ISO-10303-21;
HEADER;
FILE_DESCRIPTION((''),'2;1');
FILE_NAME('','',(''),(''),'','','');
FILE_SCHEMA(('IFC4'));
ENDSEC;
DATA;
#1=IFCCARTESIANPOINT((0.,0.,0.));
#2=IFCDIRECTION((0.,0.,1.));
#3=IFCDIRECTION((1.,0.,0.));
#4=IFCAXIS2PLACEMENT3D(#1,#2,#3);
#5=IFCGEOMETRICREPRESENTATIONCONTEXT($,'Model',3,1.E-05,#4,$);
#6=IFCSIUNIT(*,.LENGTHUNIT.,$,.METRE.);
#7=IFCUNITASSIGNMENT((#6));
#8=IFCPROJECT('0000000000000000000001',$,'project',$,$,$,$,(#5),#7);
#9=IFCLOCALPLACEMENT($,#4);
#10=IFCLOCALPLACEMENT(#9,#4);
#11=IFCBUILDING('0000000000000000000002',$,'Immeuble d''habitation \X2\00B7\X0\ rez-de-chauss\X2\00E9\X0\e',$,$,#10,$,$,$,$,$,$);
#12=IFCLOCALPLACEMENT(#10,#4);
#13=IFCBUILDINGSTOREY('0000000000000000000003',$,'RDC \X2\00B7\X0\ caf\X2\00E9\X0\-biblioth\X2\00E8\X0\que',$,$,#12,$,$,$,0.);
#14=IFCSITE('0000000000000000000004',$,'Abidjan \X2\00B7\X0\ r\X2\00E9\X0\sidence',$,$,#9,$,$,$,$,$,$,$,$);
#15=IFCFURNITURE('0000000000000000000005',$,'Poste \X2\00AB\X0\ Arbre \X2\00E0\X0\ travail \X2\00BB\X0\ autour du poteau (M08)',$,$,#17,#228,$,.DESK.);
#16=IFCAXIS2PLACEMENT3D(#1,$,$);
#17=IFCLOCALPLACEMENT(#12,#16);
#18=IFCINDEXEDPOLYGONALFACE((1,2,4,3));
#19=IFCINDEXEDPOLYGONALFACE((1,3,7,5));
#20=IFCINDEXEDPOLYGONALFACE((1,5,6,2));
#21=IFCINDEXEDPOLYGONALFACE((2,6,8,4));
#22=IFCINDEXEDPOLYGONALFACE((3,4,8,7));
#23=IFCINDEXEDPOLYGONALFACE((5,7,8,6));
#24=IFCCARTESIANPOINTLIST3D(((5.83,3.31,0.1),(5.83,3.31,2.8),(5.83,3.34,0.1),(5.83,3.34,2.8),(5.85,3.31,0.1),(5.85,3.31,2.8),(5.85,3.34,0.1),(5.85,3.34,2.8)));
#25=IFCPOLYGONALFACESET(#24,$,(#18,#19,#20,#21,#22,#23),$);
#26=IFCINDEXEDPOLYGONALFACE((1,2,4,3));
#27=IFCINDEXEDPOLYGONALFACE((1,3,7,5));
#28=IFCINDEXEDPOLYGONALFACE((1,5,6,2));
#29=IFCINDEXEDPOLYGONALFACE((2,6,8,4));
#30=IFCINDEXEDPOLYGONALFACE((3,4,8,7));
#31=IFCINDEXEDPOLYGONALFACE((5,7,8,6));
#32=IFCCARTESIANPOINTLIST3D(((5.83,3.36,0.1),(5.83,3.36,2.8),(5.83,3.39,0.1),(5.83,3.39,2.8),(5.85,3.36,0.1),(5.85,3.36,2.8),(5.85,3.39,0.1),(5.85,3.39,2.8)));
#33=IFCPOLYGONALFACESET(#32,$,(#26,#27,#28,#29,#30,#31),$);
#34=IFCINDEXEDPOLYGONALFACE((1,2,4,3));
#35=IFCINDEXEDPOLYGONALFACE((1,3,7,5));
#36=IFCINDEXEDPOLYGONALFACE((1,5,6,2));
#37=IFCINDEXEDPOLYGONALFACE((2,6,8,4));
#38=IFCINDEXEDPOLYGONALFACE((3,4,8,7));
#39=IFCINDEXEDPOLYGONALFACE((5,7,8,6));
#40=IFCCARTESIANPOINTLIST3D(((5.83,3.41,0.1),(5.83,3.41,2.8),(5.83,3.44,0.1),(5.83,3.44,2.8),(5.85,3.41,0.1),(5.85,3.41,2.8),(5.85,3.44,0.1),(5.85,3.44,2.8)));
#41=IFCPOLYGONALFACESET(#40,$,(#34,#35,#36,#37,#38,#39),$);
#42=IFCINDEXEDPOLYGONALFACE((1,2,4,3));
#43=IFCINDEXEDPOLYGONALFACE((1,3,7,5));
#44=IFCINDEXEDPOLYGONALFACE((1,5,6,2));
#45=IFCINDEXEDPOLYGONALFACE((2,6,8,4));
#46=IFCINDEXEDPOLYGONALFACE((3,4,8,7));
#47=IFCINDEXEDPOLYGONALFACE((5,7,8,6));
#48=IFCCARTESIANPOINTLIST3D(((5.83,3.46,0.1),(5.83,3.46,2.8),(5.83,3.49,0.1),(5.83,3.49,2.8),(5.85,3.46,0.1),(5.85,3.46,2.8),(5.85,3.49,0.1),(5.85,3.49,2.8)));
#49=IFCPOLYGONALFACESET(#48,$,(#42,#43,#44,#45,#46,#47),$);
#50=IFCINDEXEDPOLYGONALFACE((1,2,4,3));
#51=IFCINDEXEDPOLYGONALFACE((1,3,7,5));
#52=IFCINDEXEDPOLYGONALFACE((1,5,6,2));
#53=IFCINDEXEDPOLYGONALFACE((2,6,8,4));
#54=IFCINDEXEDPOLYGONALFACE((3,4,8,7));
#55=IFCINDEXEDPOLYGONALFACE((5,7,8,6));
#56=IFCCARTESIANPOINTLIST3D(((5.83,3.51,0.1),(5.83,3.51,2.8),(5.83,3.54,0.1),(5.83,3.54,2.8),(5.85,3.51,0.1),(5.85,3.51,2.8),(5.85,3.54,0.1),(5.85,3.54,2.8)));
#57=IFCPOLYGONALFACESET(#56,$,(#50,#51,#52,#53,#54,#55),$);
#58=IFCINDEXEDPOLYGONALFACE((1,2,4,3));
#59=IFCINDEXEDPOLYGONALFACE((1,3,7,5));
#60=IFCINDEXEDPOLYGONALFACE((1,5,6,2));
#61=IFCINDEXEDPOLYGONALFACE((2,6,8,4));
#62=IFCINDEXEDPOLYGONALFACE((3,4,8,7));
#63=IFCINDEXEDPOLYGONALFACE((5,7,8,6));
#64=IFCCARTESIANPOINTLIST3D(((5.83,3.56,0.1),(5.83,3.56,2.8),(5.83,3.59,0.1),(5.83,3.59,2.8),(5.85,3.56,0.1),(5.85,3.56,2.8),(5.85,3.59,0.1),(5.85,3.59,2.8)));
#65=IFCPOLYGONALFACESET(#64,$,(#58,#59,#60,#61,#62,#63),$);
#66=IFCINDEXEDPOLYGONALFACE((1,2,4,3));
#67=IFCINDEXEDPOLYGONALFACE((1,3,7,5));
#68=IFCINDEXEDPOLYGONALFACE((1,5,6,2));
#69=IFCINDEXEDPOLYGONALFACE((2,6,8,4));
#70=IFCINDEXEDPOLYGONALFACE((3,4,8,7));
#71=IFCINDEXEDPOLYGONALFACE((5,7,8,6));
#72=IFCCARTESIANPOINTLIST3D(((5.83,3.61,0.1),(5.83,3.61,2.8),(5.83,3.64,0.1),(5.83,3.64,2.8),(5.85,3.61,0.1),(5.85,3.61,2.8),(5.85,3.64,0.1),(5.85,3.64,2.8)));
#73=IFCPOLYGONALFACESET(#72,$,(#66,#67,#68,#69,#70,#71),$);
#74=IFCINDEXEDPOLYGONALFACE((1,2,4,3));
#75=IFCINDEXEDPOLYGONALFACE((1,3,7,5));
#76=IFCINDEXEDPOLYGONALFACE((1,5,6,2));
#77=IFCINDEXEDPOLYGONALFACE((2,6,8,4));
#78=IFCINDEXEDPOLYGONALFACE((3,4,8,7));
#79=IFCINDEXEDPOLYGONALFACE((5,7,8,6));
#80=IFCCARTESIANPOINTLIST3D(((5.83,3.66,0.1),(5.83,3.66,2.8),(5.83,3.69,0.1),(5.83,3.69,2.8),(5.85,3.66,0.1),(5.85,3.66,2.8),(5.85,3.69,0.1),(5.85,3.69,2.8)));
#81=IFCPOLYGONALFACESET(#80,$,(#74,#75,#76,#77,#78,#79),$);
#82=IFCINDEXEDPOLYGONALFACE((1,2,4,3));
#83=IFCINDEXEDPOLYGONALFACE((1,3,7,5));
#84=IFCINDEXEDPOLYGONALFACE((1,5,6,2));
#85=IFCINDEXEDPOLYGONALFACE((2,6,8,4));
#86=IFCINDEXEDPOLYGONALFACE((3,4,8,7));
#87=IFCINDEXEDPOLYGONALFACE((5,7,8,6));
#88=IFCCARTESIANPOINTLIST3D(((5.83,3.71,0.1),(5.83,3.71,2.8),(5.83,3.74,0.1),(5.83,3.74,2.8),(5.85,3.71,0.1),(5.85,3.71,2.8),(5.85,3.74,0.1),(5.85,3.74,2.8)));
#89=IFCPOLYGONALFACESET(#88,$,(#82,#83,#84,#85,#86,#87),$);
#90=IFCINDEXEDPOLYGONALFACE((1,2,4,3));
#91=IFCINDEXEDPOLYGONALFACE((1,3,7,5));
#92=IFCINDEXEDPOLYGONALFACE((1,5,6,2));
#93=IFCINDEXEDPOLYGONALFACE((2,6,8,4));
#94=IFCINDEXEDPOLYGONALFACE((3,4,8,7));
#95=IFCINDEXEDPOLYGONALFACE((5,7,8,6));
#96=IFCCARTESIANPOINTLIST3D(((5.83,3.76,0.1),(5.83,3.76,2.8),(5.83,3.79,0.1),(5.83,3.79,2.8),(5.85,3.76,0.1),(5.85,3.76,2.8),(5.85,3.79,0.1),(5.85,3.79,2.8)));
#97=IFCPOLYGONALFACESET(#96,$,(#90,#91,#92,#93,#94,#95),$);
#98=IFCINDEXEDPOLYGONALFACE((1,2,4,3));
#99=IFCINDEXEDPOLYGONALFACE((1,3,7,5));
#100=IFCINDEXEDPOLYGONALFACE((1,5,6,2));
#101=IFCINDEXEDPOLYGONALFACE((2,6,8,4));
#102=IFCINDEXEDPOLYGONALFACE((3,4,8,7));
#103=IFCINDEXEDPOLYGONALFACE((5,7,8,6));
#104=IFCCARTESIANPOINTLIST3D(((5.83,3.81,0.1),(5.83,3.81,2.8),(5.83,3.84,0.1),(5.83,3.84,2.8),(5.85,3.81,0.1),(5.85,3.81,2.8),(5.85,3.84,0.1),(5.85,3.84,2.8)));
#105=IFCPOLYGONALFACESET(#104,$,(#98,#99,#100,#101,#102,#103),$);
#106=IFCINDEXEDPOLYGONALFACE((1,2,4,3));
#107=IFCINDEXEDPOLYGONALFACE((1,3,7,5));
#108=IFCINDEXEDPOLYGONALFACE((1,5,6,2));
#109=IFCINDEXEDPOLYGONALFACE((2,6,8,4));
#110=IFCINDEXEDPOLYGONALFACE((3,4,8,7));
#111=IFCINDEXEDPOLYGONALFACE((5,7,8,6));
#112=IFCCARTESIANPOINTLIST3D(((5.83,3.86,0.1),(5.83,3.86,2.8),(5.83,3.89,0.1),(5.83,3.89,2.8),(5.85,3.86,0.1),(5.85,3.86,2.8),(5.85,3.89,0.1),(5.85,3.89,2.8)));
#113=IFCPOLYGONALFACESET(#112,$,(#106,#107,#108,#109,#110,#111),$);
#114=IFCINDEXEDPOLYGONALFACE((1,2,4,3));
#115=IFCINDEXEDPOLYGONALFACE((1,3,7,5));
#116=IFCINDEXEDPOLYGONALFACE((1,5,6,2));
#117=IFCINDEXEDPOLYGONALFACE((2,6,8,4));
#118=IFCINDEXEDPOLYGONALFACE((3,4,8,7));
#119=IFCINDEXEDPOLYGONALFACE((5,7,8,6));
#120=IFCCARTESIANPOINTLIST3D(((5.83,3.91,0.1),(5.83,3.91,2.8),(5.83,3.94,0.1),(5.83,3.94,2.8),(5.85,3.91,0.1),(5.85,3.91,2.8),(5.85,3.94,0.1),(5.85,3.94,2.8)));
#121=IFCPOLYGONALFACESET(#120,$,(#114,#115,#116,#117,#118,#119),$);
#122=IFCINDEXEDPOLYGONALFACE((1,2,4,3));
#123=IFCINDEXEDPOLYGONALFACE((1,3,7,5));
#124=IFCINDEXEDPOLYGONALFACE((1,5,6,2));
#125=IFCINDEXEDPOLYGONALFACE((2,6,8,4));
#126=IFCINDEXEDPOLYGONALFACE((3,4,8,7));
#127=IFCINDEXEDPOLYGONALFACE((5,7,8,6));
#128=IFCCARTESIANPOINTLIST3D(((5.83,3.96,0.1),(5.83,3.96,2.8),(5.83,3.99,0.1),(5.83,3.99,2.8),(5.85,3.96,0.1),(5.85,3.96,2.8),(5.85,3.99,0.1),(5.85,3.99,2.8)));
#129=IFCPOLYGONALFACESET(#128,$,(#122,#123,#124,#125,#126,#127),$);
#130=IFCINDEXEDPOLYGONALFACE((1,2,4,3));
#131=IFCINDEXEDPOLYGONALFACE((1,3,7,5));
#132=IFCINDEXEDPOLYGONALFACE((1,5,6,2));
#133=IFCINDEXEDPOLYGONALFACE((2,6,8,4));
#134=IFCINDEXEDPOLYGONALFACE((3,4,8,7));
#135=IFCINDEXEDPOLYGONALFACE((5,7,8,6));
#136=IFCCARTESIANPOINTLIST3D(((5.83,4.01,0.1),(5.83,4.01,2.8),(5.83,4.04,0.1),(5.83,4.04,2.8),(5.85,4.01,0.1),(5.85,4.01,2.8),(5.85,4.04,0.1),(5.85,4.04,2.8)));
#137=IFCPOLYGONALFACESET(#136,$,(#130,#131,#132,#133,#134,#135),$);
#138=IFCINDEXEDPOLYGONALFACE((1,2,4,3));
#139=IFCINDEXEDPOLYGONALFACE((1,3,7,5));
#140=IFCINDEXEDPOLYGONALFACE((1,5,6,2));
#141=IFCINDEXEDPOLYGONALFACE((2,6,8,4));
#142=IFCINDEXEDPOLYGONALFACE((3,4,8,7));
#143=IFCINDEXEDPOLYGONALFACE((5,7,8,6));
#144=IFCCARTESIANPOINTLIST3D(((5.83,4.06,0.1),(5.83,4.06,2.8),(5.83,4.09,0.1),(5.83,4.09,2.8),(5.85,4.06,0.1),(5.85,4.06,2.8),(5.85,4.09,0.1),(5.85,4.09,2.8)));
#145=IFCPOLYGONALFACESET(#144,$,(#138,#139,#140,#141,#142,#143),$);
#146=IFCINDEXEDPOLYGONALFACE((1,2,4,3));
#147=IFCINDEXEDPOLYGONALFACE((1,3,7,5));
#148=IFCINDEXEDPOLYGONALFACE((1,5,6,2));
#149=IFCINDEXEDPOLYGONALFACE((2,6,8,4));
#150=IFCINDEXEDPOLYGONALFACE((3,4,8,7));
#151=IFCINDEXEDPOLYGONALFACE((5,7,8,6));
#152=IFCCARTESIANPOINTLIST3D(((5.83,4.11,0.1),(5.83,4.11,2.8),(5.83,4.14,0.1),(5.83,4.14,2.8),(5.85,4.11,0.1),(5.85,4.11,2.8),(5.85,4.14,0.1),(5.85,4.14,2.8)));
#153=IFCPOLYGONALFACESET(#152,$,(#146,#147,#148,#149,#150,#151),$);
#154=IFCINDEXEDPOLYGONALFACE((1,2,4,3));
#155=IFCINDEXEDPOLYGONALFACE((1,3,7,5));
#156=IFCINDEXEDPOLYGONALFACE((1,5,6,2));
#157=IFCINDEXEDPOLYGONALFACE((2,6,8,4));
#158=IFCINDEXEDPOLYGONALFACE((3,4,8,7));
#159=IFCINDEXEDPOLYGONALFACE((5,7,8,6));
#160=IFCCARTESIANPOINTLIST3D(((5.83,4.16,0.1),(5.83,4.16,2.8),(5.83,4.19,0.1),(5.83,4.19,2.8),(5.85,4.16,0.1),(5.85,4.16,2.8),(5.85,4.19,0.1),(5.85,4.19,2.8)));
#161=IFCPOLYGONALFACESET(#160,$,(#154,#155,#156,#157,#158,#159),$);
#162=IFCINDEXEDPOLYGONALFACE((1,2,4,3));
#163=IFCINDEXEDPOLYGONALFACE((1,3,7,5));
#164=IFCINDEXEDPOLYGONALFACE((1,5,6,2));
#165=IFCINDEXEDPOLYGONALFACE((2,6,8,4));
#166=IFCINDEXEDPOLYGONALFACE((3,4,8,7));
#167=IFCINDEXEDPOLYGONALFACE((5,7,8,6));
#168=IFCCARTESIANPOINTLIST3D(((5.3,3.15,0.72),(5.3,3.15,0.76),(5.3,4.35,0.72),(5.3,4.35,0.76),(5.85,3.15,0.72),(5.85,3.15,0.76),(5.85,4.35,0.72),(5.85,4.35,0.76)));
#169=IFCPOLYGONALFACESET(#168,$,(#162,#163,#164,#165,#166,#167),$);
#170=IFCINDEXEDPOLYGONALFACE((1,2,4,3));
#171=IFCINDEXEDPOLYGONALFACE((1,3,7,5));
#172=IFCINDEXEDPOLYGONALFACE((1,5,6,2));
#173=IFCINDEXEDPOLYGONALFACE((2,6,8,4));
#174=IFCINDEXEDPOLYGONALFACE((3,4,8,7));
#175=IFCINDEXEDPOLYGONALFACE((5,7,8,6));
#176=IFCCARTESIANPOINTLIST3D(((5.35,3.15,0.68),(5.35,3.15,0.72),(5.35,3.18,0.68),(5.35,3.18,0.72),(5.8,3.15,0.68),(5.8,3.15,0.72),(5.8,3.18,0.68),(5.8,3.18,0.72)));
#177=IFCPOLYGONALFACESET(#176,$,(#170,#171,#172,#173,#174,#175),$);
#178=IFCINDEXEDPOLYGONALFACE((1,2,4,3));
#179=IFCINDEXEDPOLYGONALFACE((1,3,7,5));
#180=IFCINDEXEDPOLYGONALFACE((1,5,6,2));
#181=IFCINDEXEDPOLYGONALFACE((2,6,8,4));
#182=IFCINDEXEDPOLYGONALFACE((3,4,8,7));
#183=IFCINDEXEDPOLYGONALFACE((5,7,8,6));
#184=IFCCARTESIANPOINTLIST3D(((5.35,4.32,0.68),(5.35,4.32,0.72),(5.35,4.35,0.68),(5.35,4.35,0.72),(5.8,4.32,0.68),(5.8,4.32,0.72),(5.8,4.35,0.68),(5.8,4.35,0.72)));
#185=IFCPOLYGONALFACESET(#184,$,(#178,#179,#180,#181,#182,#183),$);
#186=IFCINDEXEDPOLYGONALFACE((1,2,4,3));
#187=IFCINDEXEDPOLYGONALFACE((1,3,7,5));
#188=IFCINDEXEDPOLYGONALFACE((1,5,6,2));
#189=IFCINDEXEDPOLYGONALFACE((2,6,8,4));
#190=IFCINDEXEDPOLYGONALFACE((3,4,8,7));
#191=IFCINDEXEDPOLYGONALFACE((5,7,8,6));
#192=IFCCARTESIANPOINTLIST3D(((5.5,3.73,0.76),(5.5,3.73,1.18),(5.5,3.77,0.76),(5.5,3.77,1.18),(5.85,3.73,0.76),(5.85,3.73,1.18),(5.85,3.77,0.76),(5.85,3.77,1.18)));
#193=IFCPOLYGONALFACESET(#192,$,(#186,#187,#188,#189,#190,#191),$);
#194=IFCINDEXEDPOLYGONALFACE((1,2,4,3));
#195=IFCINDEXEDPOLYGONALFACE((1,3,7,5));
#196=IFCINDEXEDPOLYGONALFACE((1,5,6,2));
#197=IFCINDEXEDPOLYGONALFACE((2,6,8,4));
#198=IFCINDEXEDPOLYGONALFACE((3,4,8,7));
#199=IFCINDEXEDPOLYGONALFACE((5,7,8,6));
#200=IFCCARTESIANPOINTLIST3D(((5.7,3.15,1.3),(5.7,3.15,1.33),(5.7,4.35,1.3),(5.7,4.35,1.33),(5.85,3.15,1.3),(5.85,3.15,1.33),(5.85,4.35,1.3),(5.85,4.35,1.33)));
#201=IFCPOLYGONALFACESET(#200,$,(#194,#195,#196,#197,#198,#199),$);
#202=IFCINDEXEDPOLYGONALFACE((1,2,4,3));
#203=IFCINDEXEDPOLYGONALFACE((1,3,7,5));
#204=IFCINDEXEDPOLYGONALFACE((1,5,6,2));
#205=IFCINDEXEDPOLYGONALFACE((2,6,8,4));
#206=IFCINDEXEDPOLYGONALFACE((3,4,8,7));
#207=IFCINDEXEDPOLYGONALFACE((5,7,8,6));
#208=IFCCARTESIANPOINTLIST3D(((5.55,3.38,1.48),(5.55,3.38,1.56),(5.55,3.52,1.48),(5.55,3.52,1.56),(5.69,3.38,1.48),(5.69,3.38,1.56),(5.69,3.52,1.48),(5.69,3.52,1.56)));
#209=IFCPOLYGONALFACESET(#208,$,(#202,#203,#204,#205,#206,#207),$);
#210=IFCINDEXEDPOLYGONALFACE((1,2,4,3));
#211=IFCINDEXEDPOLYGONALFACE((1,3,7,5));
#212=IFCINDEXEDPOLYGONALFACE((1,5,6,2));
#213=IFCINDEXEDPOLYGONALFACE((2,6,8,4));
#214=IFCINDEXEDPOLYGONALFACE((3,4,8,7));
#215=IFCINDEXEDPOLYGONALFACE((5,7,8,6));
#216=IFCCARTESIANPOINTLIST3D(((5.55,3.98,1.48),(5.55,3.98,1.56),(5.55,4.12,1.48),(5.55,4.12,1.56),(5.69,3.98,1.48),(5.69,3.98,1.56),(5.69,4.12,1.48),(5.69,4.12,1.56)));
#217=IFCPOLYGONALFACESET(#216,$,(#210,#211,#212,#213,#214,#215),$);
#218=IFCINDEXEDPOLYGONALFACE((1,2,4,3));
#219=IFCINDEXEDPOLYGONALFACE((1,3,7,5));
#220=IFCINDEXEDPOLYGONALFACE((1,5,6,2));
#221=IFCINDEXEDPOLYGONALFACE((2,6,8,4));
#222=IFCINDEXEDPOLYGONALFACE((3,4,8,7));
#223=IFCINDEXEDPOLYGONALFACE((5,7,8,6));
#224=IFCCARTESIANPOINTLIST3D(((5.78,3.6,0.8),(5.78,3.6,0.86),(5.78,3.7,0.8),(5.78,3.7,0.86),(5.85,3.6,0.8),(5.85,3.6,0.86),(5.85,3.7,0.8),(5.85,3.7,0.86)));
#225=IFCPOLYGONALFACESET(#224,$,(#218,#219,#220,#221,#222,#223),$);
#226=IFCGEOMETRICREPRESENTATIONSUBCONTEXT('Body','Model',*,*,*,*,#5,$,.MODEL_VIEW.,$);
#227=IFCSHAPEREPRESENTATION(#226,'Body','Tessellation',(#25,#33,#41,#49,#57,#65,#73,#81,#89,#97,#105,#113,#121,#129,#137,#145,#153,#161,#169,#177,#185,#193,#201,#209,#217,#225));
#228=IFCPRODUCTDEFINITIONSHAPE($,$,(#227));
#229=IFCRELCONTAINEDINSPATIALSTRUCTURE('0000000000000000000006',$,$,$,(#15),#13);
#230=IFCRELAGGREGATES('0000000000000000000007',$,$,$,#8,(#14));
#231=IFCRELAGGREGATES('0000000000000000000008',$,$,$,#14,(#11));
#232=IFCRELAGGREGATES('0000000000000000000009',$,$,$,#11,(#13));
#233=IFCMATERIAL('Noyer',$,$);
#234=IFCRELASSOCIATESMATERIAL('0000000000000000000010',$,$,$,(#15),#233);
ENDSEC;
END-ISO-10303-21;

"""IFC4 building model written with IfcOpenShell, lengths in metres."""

from ifc_helpers import new_model, si_unit, frame, frame_2d, origin_with_axes, place, context, subcontext, project, spatial, rectangle, extrude, material, element, save


model = new_model("IFC4")

# Units and contexts
model_context = context("Model", 3, precision=1e-05, world=origin_with_axes())
body_context = subcontext(model_context, "Body", "Model", "MODEL_VIEW")
ifc_project = project(units=[si_unit("LENGTHUNIT", "METRE")], contexts=[model_context])

# Site, building, storey
site_placement = place(None, origin_with_axes())
site = spatial("IfcSite", under=ifc_project, at=site_placement, Name="Abidjan · résidence")
building_placement = place(site_placement, origin_with_axes())
building = spatial("IfcBuilding", under=site, at=building_placement, Name="Immeuble d'habitation · rez-de-chaussée")
storey_placement = place(building_placement, origin_with_axes())
storey = spatial("IfcBuildingStorey", under=building, at=storey_placement, Name="RDC · café-bibliothèque", Elevation=0.0)

# Furniture
ifc_material_1 = material(Name="Noyer")
furniture_1_placement = place(storey_placement, origin_with_axes())
element("IfcFurniture", 1, at=furniture_1_placement, inside=storey, material=ifc_material_1, Name="Poste « Arbre à travail » autour du poteau (M08)", PredefinedType="DESK", context=body_context, shape_type="SweptSolid", body=[
    extrude(rectangle(XDim=0.02, YDim=0.03, at=frame_2d((5.84, 3.325))), frame((0.0, 0.0, 0.1)), (0.0, 0.0, 1.0), 2.7),
    extrude(rectangle(XDim=0.02, YDim=0.03, at=frame_2d((5.84, 3.375))), frame((0.0, 0.0, 0.1)), (0.0, 0.0, 1.0), 2.7),
    extrude(rectangle(XDim=0.02, YDim=0.03, at=frame_2d((5.84, 3.425))), frame((0.0, 0.0, 0.1)), (0.0, 0.0, 1.0), 2.7),
    extrude(rectangle(XDim=0.02, YDim=0.03, at=frame_2d((5.84, 3.475))), frame((0.0, 0.0, 0.1)), (0.0, 0.0, 1.0), 2.7),
    extrude(rectangle(XDim=0.02, YDim=0.03, at=frame_2d((5.84, 3.525))), frame((0.0, 0.0, 0.1)), (0.0, 0.0, 1.0), 2.7),
    extrude(rectangle(XDim=0.02, YDim=0.03, at=frame_2d((5.84, 3.575))), frame((0.0, 0.0, 0.1)), (0.0, 0.0, 1.0), 2.7),
    extrude(rectangle(XDim=0.02, YDim=0.03, at=frame_2d((5.84, 3.625))), frame((0.0, 0.0, 0.1)), (0.0, 0.0, 1.0), 2.7),
    extrude(rectangle(XDim=0.02, YDim=0.03, at=frame_2d((5.84, 3.675))), frame((0.0, 0.0, 0.1)), (0.0, 0.0, 1.0), 2.7),
    extrude(rectangle(XDim=0.02, YDim=0.03, at=frame_2d((5.84, 3.725))), frame((0.0, 0.0, 0.1)), (0.0, 0.0, 1.0), 2.7),
    extrude(rectangle(XDim=0.02, YDim=0.03, at=frame_2d((5.84, 3.775))), frame((0.0, 0.0, 0.1)), (0.0, 0.0, 1.0), 2.7),
    extrude(rectangle(XDim=0.02, YDim=0.03, at=frame_2d((5.84, 3.825))), frame((0.0, 0.0, 0.1)), (0.0, 0.0, 1.0), 2.7),
    extrude(rectangle(XDim=0.02, YDim=0.03, at=frame_2d((5.84, 3.875))), frame((0.0, 0.0, 0.1)), (0.0, 0.0, 1.0), 2.7),
    extrude(rectangle(XDim=0.02, YDim=0.03, at=frame_2d((5.84, 3.925))), frame((0.0, 0.0, 0.1)), (0.0, 0.0, 1.0), 2.7),
    extrude(rectangle(XDim=0.02, YDim=0.03, at=frame_2d((5.84, 3.975))), frame((0.0, 0.0, 0.1)), (0.0, 0.0, 1.0), 2.7),
    extrude(rectangle(XDim=0.02, YDim=0.03, at=frame_2d((5.84, 4.025))), frame((0.0, 0.0, 0.1)), (0.0, 0.0, 1.0), 2.7),
    extrude(rectangle(XDim=0.02, YDim=0.03, at=frame_2d((5.84, 4.075))), frame((0.0, 0.0, 0.1)), (0.0, 0.0, 1.0), 2.7),
    extrude(rectangle(XDim=0.02, YDim=0.03, at=frame_2d((5.84, 4.125))), frame((0.0, 0.0, 0.1)), (0.0, 0.0, 1.0), 2.7),
    extrude(rectangle(XDim=0.02, YDim=0.03, at=frame_2d((5.84, 4.175))), frame((0.0, 0.0, 0.1)), (0.0, 0.0, 1.0), 2.7),
    extrude(rectangle(XDim=0.55, YDim=1.2, at=frame_2d((5.575, 3.75))), frame((0.0, 0.0, 0.72)), (0.0, 0.0, 1.0), 0.04),
    extrude(rectangle(XDim=0.45, YDim=0.03, at=frame_2d((5.575, 3.165))), frame((0.0, 0.0, 0.68)), (0.0, 0.0, 1.0), 0.04),
    extrude(rectangle(XDim=0.45, YDim=0.03, at=frame_2d((5.575, 4.335))), frame((0.0, 0.0, 0.68)), (0.0, 0.0, 1.0), 0.04),
    extrude(rectangle(XDim=0.35, YDim=0.04, at=frame_2d((5.675, 3.75))), frame((0.0, 0.0, 0.76)), (0.0, 0.0, 1.0), 0.42),
    extrude(rectangle(XDim=0.15, YDim=1.2, at=frame_2d((5.775, 3.75))), frame((0.0, 0.0, 1.3)), (0.0, 0.0, 1.0), 0.03),
    extrude(rectangle(XDim=0.14, YDim=0.14, at=frame_2d((5.62, 3.45))), frame((0.0, 0.0, 1.48)), (0.0, 0.0, 1.0), 0.08),
    extrude(rectangle(XDim=0.14, YDim=0.14, at=frame_2d((5.62, 4.05))), frame((0.0, 0.0, 1.48)), (0.0, 0.0, 1.0), 0.08),
    extrude(rectangle(XDim=0.07, YDim=0.1, at=frame_2d((5.815, 3.65))), frame((0.0, 0.0, 0.8)), (0.0, 0.0, 1.0), 0.06),
])

save(model, "model.ifc")
